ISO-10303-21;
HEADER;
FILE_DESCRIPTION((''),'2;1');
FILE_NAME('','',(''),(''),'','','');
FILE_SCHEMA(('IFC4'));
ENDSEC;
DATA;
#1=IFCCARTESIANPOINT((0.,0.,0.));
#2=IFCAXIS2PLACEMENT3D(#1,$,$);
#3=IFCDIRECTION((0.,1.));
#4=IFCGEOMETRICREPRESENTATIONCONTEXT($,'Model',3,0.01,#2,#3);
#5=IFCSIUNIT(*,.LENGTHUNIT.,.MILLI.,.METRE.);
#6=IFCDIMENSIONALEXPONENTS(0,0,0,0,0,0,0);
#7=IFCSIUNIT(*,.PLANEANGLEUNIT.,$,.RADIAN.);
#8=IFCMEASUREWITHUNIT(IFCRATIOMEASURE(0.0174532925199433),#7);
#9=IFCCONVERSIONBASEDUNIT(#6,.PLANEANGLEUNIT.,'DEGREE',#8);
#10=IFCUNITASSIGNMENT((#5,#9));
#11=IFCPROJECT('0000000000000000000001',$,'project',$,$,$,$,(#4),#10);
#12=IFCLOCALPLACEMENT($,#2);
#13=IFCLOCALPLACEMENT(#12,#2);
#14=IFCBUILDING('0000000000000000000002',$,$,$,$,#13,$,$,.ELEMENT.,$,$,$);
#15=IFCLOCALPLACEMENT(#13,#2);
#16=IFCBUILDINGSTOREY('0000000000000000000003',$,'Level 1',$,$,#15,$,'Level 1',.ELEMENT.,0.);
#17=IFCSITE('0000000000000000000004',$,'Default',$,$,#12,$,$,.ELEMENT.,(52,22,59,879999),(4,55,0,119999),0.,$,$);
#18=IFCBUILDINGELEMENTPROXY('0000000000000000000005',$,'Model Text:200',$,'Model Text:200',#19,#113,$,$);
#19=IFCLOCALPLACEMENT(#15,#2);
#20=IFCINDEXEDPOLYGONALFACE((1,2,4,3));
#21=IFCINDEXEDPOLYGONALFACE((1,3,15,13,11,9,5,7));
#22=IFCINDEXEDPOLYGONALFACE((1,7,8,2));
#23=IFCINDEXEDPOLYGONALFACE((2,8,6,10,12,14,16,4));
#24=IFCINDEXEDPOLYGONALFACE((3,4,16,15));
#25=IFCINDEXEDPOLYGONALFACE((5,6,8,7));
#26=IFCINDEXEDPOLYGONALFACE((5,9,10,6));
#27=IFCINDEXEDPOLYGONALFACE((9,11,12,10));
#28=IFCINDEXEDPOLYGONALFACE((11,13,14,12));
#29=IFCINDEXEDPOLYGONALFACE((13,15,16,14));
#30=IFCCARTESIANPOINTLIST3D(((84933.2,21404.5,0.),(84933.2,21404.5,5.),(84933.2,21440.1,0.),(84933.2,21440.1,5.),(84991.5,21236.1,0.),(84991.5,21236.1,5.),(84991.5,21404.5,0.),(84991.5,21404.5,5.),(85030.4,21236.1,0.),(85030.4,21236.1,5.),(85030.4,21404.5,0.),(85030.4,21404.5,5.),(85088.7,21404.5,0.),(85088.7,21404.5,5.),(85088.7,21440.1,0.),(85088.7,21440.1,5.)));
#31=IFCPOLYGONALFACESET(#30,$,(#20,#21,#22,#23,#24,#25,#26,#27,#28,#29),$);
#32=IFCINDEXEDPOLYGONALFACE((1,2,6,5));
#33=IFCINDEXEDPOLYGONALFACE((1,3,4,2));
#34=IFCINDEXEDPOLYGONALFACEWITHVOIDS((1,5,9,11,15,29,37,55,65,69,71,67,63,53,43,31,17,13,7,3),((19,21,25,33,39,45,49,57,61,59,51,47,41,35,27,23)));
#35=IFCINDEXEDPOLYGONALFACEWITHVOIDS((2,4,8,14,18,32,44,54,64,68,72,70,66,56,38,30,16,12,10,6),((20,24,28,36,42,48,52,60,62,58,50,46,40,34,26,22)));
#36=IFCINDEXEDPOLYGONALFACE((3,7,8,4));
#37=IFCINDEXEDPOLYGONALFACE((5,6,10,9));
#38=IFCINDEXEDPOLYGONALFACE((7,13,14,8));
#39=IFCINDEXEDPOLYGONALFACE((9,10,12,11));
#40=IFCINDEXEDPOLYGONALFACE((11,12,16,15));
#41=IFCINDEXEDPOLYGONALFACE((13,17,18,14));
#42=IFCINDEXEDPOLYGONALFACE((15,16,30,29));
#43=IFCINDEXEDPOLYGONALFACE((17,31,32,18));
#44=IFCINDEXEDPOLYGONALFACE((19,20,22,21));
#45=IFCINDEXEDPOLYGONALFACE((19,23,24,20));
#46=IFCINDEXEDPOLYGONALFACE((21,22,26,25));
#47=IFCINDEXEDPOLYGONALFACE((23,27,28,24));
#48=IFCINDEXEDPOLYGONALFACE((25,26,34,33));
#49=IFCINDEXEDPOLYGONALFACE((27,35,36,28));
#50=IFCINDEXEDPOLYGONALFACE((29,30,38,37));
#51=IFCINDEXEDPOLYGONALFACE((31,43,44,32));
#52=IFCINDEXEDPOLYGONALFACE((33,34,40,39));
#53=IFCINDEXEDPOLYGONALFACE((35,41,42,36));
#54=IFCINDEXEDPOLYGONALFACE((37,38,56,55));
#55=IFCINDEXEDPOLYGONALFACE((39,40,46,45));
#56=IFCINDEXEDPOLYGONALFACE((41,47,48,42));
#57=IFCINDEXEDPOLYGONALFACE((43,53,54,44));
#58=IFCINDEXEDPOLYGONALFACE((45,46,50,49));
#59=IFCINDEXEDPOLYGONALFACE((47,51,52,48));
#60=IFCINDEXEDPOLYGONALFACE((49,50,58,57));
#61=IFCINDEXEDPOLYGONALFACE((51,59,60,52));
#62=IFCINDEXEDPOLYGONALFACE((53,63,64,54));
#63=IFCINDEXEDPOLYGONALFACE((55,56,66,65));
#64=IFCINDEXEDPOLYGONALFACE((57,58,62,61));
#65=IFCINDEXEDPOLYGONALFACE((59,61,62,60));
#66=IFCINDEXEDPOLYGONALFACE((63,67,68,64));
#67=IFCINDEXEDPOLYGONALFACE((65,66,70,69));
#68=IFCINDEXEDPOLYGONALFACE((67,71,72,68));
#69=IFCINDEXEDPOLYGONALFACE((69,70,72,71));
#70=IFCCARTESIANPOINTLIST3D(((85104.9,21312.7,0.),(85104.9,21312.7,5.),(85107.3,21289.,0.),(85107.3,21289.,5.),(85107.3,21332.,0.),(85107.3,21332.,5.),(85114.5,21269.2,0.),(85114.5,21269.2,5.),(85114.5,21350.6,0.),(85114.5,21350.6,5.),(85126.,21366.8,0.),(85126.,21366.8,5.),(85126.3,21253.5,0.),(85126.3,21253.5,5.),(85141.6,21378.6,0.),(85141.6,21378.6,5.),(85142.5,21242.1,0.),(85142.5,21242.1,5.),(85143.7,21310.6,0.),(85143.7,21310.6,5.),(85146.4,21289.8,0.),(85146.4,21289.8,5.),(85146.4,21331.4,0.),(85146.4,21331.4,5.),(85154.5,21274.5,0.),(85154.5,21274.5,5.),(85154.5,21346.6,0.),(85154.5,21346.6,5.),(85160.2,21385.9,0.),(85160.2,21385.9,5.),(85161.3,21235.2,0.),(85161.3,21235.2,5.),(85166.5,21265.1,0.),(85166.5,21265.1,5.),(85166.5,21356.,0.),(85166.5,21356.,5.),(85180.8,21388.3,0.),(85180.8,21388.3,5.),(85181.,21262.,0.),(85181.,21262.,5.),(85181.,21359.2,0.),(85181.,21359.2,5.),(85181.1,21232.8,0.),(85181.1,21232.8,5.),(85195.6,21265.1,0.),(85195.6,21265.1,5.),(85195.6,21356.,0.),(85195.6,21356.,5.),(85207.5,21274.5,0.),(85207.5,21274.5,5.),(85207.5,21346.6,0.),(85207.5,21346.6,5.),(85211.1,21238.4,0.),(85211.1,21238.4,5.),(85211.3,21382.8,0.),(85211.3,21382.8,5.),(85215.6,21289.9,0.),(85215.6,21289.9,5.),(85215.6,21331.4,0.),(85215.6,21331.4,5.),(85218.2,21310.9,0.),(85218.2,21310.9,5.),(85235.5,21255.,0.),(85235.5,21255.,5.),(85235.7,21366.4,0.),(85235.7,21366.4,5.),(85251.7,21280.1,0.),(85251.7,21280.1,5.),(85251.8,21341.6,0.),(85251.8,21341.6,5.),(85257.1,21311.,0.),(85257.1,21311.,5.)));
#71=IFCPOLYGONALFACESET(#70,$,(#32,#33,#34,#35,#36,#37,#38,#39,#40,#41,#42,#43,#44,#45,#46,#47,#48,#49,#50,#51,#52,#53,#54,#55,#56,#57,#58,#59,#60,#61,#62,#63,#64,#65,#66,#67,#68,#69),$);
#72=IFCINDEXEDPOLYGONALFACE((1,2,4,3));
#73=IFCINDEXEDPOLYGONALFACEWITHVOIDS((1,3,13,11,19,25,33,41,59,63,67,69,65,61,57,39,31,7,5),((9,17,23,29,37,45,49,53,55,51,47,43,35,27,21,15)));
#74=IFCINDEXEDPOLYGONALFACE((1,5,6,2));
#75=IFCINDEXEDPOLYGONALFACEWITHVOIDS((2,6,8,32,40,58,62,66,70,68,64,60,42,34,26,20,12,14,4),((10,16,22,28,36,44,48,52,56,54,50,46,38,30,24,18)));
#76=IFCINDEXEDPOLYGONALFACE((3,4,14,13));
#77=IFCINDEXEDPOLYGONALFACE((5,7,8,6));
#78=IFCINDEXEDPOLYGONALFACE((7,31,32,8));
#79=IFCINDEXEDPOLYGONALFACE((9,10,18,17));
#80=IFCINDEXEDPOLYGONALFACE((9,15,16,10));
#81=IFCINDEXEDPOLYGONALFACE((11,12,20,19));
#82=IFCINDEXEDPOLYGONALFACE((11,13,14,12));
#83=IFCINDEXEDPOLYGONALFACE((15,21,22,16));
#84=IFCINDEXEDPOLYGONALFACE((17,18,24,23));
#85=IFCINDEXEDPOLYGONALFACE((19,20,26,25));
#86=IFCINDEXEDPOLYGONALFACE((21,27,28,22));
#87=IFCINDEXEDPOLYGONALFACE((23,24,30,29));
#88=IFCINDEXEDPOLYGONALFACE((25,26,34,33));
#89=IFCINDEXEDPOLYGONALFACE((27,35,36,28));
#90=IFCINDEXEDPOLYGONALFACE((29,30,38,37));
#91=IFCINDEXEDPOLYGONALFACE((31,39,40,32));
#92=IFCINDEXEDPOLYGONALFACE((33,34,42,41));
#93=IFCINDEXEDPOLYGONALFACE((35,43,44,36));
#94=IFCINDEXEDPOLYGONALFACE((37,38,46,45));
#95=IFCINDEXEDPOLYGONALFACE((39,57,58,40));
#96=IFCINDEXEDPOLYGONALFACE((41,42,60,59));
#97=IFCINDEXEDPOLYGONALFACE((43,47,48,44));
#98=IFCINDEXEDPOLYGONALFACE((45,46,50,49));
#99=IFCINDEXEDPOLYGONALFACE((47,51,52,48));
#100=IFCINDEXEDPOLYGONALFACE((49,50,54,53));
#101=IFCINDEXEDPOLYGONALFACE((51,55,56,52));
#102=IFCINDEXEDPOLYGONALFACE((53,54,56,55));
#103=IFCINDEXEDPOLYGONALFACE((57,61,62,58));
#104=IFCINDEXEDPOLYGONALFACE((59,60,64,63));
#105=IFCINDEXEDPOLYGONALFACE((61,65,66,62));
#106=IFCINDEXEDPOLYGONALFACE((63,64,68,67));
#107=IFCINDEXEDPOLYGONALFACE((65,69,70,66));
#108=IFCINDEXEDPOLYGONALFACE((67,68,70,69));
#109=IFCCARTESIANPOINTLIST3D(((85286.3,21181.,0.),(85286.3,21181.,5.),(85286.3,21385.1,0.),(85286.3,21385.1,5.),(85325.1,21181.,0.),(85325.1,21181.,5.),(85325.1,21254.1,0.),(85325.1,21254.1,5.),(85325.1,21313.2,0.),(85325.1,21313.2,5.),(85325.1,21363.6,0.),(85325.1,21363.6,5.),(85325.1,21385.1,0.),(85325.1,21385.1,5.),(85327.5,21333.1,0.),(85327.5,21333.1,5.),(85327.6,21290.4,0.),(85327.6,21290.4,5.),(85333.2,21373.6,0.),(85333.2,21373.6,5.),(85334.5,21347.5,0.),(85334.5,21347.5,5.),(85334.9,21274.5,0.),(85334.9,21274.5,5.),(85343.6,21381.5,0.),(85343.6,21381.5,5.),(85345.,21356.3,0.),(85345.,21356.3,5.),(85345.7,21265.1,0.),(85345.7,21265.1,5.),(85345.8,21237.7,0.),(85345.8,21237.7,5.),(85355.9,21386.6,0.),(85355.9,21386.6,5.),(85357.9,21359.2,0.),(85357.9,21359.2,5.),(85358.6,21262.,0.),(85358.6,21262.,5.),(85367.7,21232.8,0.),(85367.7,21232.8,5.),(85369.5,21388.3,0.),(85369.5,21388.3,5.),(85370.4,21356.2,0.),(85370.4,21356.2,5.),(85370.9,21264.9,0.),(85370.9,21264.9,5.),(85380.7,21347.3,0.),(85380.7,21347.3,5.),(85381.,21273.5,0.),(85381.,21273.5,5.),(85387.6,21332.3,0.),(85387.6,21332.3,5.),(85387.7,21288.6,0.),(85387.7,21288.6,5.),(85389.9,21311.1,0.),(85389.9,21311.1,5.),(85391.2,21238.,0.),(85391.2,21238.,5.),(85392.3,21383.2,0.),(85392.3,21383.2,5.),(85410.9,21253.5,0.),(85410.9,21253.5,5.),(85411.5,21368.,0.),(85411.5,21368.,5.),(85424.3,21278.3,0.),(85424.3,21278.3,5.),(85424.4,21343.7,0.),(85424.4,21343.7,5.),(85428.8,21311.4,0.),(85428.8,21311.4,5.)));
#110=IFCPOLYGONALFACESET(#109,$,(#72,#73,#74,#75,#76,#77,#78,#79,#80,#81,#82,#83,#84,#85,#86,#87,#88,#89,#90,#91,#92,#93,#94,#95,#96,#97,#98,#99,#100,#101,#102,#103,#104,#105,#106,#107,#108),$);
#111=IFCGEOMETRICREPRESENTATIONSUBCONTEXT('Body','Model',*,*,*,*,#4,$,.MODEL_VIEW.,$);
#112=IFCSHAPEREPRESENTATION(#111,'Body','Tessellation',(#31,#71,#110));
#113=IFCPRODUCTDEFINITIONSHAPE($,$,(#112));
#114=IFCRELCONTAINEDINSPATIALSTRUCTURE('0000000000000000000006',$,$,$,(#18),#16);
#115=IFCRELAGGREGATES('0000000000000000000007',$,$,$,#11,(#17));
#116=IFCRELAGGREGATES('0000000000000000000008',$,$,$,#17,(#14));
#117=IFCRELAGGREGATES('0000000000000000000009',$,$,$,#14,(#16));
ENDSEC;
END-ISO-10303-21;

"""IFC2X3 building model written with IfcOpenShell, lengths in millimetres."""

from ifc_helpers import new_model, entity, si_unit, converted_unit, direction, frame, origin, place, context, subcontext, project, spatial, polyline, outline, extrude, element, save


model = new_model("IFC2X3")

# Units and contexts
model_context = context("Model", 3, precision=0.01, world=origin(), true_north=direction((0.0, 1.0)))
body_context = subcontext(model_context, "Body", "Model", "MODEL_VIEW")
ifc_project = project(units=[si_unit("LENGTHUNIT", "METRE", prefix="MILLI"), converted_unit("PLANEANGLEUNIT", "DEGREE", entity("IfcRatioMeasure", 0.0174532925199433), si_unit("PLANEANGLEUNIT", "RADIAN"), dimensions=[0, 0, 0, 0, 0, 0, 0])], contexts=[model_context])

# Site, building, storey
site_placement = place(None, origin())
site = spatial("IfcSite", under=ifc_project, at=site_placement, Name="Default", CompositionType="ELEMENT", RefLatitude=(52, 22, 59, 879999), RefLongitude=(4, 55, 0, 119999), RefElevation=0.0)
building_placement = place(site_placement, origin())
building = spatial("IfcBuilding", under=site, at=building_placement, CompositionType="ELEMENT")
storey_placement = place(building_placement, origin())
storey = spatial("IfcBuildingStorey", under=building, at=storey_placement, Name="Level 1", LongName="Level 1", CompositionType="ELEMENT", Elevation=0.0)

# Building element proxy
proxy_1_placement = place(building_placement, origin())
element("IfcBuildingElementProxy", 1, at=proxy_1_placement, inside=storey, Name="Model Text:200", ObjectType="Model Text:200", context=body_context, shape_type="SweptSolid", body=[
    extrude(outline(polyline([(-19.4, -135.2), (19.4, -135.2), (19.4, 33.2), (77.7, 33.2), (77.7, 68.8), (-77.7, 68.8), (-77.7, 33.2), (-19.4, 33.2), (-19.4, -135.2)])), frame((85010.9, 21371.3, 0.0)), (0.0, 0.0, 1.0), 5.0),
    extrude(outline(polyline([(-8.8, -65.7), (15.1, -65.7), (35.5, -60.5), (52.3, -50.4), (65.3, -35.4), (74.1, -17.3), (78.4, 2.1), (75.9, 32.5), (61.8, 58.5), (38.4, 77.1), (8.3, 85.6), (-22.7, 83.3), (-49.0, 69.9), (-67.8, 47.3), (-76.3, 17.5), (-76.0, -3.3), (-70.7, -22.5), (-60.5, -39.2), (-45.5, -52.3), (-27.7, -61.4), (-8.8, -65.7)]), holes=[polyline([(-2.7, -27.2), (-23.1, -22.5), (-37.5, -12.9), (-45.7, 0.0), (-47.3, 14.8), (-42.7, 28.9), (-32.2, 39.9), (-16.3, 46.3), (4.5, 46.9), (25.1, 42.1), (39.6, 32.6), (47.7, 19.7), (49.4, 5.0), (44.8, -9.2), (34.2, -20.2), (18.2, -26.7), (-2.7, -27.2)])]), frame((85171.1, 21310.6, 0.0), z_axis=(0.0, 0.0, 1.0), x_axis=(0.100608, -0.994926, 0.0)), (0.0, 0.0, 1.0), 5.0),
    extrude(outline(polyline([(-73.1, -75.4), (130.9, -75.4), (130.9, -36.6), (57.8, -36.6), (74.3, -15.9), (79.1, 6.0), (73.9, 29.5), (58.4, 49.2), (33.6, 62.6), (0.5, 67.1), (-31.8, 62.8), (-56.1, 49.8), (-71.3, 30.7), (-76.4, 7.8), (-74.7, -5.8), (-69.6, -18.1), (-61.7, -28.5), (-51.7, -36.6), (-73.1, -36.6), (-73.1, -75.4)]), holes=[polyline([(-1.2, -36.6), (-21.2, -34.2), (-35.6, -27.2), (-44.3, -16.7), (-47.2, -3.8), (-44.3, 8.7), (-35.4, 19.0), (-20.4, 25.9), (0.8, 28.2), (23.3, 26.0), (38.5, 19.3), (47.1, 9.2), (49.9, -3.1), (46.8, -16.0), (37.4, -26.8), (21.5, -34.1), (-1.2, -36.6)])]), frame((85361.7, 21311.9, 0.0), z_axis=(0.0, 0.0, 1.0), x_axis=(0.0, -1.0, 0.0)), (0.0, 0.0, 1.0), 5.0),
])

save(model, "model.ifc")
